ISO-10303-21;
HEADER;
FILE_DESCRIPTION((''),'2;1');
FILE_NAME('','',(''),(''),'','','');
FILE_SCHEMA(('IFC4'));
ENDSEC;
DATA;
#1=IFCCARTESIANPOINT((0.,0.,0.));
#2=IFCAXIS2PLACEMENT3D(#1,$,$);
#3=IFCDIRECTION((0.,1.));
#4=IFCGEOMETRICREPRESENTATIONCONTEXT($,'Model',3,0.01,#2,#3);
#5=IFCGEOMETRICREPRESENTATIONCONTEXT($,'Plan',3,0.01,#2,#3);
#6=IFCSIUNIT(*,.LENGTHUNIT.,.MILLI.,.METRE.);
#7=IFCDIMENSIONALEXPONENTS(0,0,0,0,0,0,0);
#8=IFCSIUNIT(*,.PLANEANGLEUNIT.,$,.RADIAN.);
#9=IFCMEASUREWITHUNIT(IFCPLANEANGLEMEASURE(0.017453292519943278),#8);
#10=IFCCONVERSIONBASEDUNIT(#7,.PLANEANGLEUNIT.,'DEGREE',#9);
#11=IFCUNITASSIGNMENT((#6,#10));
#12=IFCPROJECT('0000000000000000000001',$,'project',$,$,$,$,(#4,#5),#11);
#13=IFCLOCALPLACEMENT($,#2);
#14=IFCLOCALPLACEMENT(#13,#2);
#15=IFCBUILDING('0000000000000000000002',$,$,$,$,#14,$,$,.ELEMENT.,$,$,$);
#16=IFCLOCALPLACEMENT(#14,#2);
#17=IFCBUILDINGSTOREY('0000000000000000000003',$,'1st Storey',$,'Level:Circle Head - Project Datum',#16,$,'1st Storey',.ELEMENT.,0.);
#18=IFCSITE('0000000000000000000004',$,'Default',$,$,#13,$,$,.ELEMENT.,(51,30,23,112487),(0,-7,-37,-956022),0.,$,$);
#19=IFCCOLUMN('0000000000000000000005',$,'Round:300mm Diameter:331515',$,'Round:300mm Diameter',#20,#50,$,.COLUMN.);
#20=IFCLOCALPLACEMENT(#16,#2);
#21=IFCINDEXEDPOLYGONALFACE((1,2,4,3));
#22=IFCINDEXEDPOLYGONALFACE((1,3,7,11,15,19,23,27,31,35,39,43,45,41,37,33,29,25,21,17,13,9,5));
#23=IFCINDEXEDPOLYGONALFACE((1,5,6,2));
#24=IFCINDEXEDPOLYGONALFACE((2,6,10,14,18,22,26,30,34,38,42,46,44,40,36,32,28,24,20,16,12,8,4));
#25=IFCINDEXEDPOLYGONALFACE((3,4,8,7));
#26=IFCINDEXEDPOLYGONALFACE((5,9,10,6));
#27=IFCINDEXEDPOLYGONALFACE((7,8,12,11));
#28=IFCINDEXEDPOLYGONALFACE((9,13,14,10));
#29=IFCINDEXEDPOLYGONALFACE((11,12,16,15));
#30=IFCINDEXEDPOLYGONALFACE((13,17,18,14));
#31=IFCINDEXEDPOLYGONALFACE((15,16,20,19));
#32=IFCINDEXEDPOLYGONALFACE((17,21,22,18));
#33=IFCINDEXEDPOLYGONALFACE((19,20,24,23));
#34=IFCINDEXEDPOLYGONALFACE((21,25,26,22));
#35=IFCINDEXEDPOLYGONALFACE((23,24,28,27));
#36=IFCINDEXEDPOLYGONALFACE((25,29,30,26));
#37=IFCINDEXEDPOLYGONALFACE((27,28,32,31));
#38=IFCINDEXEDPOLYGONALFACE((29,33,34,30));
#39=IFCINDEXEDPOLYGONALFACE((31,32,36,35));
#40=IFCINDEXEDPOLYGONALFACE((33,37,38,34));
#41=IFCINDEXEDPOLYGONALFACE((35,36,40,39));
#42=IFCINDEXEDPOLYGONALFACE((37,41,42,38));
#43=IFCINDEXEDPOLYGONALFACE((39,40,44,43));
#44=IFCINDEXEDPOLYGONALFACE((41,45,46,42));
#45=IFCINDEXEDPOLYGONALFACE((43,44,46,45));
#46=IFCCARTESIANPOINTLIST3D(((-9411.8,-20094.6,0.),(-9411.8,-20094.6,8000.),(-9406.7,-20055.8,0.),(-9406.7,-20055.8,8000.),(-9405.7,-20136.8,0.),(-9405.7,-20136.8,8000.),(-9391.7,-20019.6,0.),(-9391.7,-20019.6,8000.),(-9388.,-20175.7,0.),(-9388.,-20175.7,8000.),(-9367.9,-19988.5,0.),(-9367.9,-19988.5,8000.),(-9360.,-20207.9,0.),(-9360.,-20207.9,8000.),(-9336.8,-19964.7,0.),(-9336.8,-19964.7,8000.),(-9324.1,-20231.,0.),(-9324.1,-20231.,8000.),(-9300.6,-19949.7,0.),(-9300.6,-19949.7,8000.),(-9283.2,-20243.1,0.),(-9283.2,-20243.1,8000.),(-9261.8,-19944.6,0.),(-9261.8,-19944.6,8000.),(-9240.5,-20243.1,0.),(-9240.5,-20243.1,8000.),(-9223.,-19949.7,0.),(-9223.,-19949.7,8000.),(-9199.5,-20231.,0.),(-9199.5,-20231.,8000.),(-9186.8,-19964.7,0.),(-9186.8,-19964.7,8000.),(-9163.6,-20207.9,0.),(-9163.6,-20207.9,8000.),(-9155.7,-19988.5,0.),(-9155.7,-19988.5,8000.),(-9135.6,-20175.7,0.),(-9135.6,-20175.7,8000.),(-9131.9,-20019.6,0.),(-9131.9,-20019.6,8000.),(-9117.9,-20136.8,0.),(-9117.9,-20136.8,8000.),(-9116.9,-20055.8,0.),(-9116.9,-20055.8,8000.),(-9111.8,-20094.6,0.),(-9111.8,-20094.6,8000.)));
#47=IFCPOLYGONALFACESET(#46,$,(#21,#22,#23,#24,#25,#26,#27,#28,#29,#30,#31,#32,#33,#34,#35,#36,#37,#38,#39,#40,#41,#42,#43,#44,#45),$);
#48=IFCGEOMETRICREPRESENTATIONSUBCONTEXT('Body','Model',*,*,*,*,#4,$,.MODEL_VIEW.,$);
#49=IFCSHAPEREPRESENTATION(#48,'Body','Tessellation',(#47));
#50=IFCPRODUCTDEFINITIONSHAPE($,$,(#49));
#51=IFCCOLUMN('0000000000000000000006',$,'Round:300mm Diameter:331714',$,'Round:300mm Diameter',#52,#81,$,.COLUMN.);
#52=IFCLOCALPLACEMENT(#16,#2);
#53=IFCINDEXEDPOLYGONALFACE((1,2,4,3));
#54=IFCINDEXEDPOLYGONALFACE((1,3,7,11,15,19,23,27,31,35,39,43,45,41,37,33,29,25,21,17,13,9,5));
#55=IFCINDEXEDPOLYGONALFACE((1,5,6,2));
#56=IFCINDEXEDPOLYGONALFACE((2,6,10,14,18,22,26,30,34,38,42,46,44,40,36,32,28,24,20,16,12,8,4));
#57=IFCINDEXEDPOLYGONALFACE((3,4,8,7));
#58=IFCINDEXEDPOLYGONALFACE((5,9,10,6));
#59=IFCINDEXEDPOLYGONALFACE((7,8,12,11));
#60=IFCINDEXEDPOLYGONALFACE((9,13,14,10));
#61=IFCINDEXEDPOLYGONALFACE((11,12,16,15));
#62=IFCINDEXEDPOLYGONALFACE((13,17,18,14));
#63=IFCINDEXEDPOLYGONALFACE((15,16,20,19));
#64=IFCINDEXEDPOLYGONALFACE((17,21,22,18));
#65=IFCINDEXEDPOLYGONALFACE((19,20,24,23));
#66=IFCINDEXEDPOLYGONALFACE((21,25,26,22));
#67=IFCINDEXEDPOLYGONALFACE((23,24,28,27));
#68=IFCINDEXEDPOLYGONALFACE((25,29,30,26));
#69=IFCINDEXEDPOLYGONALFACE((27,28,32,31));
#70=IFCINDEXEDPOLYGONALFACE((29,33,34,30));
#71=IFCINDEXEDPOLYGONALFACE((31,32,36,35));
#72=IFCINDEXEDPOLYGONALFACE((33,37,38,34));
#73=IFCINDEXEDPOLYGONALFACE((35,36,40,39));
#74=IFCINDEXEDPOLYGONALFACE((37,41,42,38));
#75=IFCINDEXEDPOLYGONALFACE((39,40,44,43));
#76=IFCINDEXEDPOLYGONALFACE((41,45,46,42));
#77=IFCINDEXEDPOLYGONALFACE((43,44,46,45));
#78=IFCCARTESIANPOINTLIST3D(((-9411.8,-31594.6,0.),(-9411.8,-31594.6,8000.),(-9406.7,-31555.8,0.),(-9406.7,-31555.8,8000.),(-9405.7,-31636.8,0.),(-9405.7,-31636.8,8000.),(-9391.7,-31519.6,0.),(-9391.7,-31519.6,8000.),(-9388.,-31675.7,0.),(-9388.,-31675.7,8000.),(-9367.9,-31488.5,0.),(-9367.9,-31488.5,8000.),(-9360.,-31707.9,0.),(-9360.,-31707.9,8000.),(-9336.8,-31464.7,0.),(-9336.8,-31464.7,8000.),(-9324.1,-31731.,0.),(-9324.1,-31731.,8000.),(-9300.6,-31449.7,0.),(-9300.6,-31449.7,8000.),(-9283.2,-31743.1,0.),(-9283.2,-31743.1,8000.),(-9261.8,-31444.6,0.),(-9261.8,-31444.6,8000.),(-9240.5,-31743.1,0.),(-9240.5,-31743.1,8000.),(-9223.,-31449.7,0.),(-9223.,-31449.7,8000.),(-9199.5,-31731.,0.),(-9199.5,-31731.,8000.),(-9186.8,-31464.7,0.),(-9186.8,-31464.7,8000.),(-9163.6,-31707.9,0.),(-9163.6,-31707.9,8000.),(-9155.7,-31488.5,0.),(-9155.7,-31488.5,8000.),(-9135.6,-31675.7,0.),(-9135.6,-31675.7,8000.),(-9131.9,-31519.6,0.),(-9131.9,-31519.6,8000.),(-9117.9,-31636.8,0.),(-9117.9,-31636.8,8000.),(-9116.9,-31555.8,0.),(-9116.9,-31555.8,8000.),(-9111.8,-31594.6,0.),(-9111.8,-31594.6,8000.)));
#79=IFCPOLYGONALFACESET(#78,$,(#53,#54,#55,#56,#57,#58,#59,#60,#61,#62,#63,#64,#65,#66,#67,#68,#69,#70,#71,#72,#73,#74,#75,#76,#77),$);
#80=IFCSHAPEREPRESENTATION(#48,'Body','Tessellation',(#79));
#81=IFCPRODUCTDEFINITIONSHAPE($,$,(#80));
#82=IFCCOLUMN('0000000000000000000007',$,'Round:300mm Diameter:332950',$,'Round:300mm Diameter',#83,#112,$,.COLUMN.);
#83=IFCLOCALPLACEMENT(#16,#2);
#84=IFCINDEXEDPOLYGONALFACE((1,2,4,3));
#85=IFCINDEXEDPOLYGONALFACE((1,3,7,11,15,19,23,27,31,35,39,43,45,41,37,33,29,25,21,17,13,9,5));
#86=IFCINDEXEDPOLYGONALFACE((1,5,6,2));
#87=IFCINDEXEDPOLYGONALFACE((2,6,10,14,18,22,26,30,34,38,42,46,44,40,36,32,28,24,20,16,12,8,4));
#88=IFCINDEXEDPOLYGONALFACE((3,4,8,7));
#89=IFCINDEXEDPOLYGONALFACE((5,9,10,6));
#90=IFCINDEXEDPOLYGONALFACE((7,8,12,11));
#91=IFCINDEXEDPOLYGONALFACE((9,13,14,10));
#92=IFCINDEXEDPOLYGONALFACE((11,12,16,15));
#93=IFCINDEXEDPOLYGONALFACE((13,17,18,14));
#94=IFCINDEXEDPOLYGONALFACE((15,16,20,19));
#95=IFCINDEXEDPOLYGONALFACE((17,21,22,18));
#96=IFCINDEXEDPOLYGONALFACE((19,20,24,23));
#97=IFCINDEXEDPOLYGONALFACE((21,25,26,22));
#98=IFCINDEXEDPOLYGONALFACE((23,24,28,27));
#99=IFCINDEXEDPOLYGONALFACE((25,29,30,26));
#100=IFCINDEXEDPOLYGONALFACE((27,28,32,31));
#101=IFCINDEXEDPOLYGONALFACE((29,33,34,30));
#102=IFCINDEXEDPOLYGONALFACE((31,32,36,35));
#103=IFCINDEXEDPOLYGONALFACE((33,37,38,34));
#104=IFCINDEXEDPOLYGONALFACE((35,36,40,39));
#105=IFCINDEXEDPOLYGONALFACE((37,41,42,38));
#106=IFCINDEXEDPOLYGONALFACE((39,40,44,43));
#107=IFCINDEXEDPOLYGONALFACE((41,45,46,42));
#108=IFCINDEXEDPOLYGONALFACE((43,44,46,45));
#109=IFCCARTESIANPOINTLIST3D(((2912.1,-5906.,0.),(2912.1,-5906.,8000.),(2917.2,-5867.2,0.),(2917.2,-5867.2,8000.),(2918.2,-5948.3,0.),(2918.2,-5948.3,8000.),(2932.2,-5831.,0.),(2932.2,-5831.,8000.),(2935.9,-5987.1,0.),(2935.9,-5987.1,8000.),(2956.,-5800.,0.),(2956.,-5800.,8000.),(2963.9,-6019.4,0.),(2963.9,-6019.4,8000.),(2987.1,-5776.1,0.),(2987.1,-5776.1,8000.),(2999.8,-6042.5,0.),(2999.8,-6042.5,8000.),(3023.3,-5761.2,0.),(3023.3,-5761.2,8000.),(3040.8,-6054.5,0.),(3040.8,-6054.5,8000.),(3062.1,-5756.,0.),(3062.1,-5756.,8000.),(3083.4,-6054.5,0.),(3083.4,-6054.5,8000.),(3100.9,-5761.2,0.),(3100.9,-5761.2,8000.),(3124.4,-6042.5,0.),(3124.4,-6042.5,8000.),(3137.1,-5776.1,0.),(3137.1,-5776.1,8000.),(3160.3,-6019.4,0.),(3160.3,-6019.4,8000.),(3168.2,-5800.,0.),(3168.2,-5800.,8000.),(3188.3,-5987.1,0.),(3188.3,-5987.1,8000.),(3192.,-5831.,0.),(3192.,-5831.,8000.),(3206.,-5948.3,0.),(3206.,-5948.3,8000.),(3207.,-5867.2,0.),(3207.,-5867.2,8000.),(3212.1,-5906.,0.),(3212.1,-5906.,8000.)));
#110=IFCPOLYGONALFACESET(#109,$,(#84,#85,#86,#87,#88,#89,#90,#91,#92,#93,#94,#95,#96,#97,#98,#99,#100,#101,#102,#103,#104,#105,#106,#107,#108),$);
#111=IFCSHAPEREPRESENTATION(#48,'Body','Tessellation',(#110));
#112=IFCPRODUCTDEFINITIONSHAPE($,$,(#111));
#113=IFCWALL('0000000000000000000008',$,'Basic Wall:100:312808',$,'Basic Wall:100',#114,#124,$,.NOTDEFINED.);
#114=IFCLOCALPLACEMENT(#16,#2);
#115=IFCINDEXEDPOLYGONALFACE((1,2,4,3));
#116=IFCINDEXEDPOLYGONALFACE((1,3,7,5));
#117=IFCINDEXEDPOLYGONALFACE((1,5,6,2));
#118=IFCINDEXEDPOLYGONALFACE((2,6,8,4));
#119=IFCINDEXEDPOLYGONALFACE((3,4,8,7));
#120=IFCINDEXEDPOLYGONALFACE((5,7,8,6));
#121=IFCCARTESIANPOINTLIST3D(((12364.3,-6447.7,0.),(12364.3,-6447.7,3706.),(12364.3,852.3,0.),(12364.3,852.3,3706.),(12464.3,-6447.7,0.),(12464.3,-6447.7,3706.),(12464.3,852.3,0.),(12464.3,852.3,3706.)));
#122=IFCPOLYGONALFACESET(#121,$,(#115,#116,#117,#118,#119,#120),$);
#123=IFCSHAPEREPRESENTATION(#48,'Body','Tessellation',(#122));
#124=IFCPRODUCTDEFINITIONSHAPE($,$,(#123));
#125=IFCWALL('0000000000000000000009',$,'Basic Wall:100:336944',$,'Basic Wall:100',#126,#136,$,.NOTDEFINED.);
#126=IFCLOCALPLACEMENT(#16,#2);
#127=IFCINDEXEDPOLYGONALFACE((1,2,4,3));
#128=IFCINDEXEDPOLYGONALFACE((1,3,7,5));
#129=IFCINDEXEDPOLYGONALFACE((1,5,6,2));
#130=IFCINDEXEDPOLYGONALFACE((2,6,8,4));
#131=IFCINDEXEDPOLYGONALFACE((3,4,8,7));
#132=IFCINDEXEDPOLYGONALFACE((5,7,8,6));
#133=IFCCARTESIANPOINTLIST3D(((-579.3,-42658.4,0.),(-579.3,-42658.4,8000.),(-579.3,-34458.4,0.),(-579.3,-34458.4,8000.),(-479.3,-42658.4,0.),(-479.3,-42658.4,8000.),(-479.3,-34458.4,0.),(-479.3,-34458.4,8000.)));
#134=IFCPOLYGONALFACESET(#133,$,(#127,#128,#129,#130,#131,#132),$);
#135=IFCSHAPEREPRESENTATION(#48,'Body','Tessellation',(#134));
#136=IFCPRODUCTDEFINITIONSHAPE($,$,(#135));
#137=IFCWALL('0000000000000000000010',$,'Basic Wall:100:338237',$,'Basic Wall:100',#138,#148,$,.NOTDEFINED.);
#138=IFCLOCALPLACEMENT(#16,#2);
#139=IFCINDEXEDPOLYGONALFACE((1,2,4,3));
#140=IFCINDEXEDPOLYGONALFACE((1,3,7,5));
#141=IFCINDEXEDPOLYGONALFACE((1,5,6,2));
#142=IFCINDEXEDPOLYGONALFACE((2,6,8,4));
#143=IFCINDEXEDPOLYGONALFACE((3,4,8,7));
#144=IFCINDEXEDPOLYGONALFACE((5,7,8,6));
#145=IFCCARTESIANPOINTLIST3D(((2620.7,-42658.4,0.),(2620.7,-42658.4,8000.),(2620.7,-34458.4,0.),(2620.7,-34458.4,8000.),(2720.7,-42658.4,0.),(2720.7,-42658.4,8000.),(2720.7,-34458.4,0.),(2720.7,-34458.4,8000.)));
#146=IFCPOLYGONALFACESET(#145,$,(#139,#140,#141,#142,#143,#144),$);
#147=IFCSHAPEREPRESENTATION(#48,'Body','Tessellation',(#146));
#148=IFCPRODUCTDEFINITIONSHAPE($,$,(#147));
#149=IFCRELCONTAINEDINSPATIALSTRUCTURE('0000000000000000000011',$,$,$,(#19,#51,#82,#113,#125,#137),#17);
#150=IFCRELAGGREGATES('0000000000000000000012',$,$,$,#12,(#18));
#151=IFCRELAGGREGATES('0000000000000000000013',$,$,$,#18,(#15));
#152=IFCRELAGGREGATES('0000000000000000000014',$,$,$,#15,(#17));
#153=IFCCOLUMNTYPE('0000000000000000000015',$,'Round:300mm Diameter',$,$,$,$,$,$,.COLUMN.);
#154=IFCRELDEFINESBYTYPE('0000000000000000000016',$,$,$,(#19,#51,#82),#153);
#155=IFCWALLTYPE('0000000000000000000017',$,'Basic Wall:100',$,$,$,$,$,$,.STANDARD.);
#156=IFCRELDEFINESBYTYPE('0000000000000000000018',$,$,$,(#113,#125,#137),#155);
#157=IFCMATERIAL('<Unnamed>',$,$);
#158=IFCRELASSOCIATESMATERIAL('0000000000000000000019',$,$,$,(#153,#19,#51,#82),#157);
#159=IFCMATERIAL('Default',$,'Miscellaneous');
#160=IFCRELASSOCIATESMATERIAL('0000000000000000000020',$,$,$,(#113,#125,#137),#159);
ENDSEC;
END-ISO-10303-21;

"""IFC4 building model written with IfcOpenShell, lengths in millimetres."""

from ifc_helpers import new_model, entity, si_unit, converted_unit, direction, frame, origin, place, context, subcontext, project, spatial, arc, indexed_curve, outline, extrude, source, transform, mapped, material, type_object, type_shapes, element, save


model = new_model("IFC4")

# Units and contexts
model_context = context("Model", 3, precision=0.01, world=origin(), true_north=direction((0.0, 1.0)))
plan_context = context("Plan", 3, precision=0.01, world=origin(), true_north=direction((0.0, 1.0)))
body_context = subcontext(model_context, "Body", "Model", "MODEL_VIEW")
ifc_project = project(units=[si_unit("LENGTHUNIT", "METRE", prefix="MILLI"), converted_unit("PLANEANGLEUNIT", "DEGREE", entity("IfcPlaneAngleMeasure", 0.017453292519943278), si_unit("PLANEANGLEUNIT", "RADIAN"), dimensions=[0, 0, 0, 0, 0, 0, 0])], contexts=[model_context, plan_context])

# Site, building, storey
site_placement = place(None, origin())
site = spatial("IfcSite", under=ifc_project, at=site_placement, Name="Default", CompositionType="ELEMENT", RefLatitude=(51, 30, 23, 112487), RefLongitude=(0, -7, -37, -956022), RefElevation=0.0)
building_placement = place(site_placement, origin())
building = spatial("IfcBuilding", under=site, at=building_placement, CompositionType="ELEMENT")
storey_placement = place(building_placement, origin())
storey = spatial("IfcBuildingStorey", under=building, at=storey_placement, Name="1st Storey", ObjectType="Level:Circle Head - Project Datum", LongName="1st Storey", CompositionType="ELEMENT", Elevation=0.0)

# Columns
ifc_material_1 = material(Name="<Unnamed>")
column_type = type_object("IfcColumnType", Name="Round:300mm Diameter", PredefinedType="COLUMN", material=ifc_material_1)
shared_shape = source(origin(), body_context, "Body", "SweptSolid", [
    extrude(outline(indexed_curve([(150.0, -50.0), (106.1, 56.1), (0.0, 100.0), (-106.1, 56.1), (-150.0, -50.0), (0.0, -200.0)], segments=[arc(1, 2, 3), arc(3, 4, 5), arc(5, 6, 1)], self_intersect=False)), frame((0.0, 50.0, 0.0)), (0.0, 0.0, 1.0), 8000.0),
])
type_shapes(column_type, [shared_shape])
for number, where, name in (
    (1, (-9261.8, -20094.6, 0.0), "Round:300mm Diameter:331515"),
    (2, (-9261.8, -31594.6, 0.0), "Round:300mm Diameter:331714"),
    (3, (3062.1, -5906.0, 0.0), "Round:300mm Diameter:332950"),
):
    element("IfcColumn", number, at=place(storey_placement, frame(where)), inside=storey, type_object=column_type, material=ifc_material_1, Name=name, ObjectType="Round:300mm Diameter", PredefinedType="COLUMN", context=body_context, shape_type="MappedRepresentation", body=[
        mapped(shared_shape, transform((0.0, 0.0, 0.0), scale=1.0)),
    ])

# Walls
ifc_material_2 = material(Name="Default", Category="Miscellaneous")
wall_type = type_object("IfcWallType", Name="Basic Wall:100", PredefinedType="STANDARD")
wall_1_placement = place(storey_placement, frame((12414.3, -6447.7, 0.0), z_axis=(0.0, 0.0, 1.0), x_axis=(0.0, 1.0, 0.0)))
element("IfcWall", 4, at=wall_1_placement, inside=storey, type_object=wall_type, material=ifc_material_2, Name="Basic Wall:100:312808", ObjectType="Basic Wall:100", PredefinedType="NOTDEFINED", context=body_context, shape_type="SweptSolid", body=[
    extrude(outline(indexed_curve([(7300.0, 50.0), (0.0, 50.0), (0.0, -50.0), (7300.0, -50.0), (7300.0, 50.0)], self_intersect=False)), origin(), (0.0, 0.0, 1.0), 3706.0),
])
wall_2_placement = place(storey_placement, frame((-529.3, -34458.4, 0.0), z_axis=(0.0, 0.0, 1.0), x_axis=(0.0, -1.0, 0.0)))
element("IfcWall", 5, at=wall_2_placement, inside=storey, type_object=wall_type, material=ifc_material_2, Name="Basic Wall:100:336944", ObjectType="Basic Wall:100", PredefinedType="NOTDEFINED", context=body_context, shape_type="SweptSolid", body=[
    extrude(outline(indexed_curve([(8200.0, 50.0), (0.0, 50.0), (0.0, -50.0), (8200.0, -50.0), (8200.0, 50.0)], self_intersect=False)), origin(), (0.0, 0.0, 1.0), 8000.0),
])
wall_3_placement = place(storey_placement, frame((2670.7, -34458.4, 0.0), z_axis=(0.0, 0.0, 1.0), x_axis=(0.0, -1.0, 0.0)))
element("IfcWall", 6, at=wall_3_placement, inside=storey, type_object=wall_type, material=ifc_material_2, Name="Basic Wall:100:338237", ObjectType="Basic Wall:100", PredefinedType="NOTDEFINED", context=body_context, shape_type="SweptSolid", body=[
    extrude(outline(indexed_curve([(8200.0, 50.0), (0.0, 50.0), (0.0, -50.0), (8200.0, -50.0), (8200.0, 50.0)], self_intersect=False)), origin(), (0.0, 0.0, 1.0), 8000.0),
])

save(model, "model.ifc")
